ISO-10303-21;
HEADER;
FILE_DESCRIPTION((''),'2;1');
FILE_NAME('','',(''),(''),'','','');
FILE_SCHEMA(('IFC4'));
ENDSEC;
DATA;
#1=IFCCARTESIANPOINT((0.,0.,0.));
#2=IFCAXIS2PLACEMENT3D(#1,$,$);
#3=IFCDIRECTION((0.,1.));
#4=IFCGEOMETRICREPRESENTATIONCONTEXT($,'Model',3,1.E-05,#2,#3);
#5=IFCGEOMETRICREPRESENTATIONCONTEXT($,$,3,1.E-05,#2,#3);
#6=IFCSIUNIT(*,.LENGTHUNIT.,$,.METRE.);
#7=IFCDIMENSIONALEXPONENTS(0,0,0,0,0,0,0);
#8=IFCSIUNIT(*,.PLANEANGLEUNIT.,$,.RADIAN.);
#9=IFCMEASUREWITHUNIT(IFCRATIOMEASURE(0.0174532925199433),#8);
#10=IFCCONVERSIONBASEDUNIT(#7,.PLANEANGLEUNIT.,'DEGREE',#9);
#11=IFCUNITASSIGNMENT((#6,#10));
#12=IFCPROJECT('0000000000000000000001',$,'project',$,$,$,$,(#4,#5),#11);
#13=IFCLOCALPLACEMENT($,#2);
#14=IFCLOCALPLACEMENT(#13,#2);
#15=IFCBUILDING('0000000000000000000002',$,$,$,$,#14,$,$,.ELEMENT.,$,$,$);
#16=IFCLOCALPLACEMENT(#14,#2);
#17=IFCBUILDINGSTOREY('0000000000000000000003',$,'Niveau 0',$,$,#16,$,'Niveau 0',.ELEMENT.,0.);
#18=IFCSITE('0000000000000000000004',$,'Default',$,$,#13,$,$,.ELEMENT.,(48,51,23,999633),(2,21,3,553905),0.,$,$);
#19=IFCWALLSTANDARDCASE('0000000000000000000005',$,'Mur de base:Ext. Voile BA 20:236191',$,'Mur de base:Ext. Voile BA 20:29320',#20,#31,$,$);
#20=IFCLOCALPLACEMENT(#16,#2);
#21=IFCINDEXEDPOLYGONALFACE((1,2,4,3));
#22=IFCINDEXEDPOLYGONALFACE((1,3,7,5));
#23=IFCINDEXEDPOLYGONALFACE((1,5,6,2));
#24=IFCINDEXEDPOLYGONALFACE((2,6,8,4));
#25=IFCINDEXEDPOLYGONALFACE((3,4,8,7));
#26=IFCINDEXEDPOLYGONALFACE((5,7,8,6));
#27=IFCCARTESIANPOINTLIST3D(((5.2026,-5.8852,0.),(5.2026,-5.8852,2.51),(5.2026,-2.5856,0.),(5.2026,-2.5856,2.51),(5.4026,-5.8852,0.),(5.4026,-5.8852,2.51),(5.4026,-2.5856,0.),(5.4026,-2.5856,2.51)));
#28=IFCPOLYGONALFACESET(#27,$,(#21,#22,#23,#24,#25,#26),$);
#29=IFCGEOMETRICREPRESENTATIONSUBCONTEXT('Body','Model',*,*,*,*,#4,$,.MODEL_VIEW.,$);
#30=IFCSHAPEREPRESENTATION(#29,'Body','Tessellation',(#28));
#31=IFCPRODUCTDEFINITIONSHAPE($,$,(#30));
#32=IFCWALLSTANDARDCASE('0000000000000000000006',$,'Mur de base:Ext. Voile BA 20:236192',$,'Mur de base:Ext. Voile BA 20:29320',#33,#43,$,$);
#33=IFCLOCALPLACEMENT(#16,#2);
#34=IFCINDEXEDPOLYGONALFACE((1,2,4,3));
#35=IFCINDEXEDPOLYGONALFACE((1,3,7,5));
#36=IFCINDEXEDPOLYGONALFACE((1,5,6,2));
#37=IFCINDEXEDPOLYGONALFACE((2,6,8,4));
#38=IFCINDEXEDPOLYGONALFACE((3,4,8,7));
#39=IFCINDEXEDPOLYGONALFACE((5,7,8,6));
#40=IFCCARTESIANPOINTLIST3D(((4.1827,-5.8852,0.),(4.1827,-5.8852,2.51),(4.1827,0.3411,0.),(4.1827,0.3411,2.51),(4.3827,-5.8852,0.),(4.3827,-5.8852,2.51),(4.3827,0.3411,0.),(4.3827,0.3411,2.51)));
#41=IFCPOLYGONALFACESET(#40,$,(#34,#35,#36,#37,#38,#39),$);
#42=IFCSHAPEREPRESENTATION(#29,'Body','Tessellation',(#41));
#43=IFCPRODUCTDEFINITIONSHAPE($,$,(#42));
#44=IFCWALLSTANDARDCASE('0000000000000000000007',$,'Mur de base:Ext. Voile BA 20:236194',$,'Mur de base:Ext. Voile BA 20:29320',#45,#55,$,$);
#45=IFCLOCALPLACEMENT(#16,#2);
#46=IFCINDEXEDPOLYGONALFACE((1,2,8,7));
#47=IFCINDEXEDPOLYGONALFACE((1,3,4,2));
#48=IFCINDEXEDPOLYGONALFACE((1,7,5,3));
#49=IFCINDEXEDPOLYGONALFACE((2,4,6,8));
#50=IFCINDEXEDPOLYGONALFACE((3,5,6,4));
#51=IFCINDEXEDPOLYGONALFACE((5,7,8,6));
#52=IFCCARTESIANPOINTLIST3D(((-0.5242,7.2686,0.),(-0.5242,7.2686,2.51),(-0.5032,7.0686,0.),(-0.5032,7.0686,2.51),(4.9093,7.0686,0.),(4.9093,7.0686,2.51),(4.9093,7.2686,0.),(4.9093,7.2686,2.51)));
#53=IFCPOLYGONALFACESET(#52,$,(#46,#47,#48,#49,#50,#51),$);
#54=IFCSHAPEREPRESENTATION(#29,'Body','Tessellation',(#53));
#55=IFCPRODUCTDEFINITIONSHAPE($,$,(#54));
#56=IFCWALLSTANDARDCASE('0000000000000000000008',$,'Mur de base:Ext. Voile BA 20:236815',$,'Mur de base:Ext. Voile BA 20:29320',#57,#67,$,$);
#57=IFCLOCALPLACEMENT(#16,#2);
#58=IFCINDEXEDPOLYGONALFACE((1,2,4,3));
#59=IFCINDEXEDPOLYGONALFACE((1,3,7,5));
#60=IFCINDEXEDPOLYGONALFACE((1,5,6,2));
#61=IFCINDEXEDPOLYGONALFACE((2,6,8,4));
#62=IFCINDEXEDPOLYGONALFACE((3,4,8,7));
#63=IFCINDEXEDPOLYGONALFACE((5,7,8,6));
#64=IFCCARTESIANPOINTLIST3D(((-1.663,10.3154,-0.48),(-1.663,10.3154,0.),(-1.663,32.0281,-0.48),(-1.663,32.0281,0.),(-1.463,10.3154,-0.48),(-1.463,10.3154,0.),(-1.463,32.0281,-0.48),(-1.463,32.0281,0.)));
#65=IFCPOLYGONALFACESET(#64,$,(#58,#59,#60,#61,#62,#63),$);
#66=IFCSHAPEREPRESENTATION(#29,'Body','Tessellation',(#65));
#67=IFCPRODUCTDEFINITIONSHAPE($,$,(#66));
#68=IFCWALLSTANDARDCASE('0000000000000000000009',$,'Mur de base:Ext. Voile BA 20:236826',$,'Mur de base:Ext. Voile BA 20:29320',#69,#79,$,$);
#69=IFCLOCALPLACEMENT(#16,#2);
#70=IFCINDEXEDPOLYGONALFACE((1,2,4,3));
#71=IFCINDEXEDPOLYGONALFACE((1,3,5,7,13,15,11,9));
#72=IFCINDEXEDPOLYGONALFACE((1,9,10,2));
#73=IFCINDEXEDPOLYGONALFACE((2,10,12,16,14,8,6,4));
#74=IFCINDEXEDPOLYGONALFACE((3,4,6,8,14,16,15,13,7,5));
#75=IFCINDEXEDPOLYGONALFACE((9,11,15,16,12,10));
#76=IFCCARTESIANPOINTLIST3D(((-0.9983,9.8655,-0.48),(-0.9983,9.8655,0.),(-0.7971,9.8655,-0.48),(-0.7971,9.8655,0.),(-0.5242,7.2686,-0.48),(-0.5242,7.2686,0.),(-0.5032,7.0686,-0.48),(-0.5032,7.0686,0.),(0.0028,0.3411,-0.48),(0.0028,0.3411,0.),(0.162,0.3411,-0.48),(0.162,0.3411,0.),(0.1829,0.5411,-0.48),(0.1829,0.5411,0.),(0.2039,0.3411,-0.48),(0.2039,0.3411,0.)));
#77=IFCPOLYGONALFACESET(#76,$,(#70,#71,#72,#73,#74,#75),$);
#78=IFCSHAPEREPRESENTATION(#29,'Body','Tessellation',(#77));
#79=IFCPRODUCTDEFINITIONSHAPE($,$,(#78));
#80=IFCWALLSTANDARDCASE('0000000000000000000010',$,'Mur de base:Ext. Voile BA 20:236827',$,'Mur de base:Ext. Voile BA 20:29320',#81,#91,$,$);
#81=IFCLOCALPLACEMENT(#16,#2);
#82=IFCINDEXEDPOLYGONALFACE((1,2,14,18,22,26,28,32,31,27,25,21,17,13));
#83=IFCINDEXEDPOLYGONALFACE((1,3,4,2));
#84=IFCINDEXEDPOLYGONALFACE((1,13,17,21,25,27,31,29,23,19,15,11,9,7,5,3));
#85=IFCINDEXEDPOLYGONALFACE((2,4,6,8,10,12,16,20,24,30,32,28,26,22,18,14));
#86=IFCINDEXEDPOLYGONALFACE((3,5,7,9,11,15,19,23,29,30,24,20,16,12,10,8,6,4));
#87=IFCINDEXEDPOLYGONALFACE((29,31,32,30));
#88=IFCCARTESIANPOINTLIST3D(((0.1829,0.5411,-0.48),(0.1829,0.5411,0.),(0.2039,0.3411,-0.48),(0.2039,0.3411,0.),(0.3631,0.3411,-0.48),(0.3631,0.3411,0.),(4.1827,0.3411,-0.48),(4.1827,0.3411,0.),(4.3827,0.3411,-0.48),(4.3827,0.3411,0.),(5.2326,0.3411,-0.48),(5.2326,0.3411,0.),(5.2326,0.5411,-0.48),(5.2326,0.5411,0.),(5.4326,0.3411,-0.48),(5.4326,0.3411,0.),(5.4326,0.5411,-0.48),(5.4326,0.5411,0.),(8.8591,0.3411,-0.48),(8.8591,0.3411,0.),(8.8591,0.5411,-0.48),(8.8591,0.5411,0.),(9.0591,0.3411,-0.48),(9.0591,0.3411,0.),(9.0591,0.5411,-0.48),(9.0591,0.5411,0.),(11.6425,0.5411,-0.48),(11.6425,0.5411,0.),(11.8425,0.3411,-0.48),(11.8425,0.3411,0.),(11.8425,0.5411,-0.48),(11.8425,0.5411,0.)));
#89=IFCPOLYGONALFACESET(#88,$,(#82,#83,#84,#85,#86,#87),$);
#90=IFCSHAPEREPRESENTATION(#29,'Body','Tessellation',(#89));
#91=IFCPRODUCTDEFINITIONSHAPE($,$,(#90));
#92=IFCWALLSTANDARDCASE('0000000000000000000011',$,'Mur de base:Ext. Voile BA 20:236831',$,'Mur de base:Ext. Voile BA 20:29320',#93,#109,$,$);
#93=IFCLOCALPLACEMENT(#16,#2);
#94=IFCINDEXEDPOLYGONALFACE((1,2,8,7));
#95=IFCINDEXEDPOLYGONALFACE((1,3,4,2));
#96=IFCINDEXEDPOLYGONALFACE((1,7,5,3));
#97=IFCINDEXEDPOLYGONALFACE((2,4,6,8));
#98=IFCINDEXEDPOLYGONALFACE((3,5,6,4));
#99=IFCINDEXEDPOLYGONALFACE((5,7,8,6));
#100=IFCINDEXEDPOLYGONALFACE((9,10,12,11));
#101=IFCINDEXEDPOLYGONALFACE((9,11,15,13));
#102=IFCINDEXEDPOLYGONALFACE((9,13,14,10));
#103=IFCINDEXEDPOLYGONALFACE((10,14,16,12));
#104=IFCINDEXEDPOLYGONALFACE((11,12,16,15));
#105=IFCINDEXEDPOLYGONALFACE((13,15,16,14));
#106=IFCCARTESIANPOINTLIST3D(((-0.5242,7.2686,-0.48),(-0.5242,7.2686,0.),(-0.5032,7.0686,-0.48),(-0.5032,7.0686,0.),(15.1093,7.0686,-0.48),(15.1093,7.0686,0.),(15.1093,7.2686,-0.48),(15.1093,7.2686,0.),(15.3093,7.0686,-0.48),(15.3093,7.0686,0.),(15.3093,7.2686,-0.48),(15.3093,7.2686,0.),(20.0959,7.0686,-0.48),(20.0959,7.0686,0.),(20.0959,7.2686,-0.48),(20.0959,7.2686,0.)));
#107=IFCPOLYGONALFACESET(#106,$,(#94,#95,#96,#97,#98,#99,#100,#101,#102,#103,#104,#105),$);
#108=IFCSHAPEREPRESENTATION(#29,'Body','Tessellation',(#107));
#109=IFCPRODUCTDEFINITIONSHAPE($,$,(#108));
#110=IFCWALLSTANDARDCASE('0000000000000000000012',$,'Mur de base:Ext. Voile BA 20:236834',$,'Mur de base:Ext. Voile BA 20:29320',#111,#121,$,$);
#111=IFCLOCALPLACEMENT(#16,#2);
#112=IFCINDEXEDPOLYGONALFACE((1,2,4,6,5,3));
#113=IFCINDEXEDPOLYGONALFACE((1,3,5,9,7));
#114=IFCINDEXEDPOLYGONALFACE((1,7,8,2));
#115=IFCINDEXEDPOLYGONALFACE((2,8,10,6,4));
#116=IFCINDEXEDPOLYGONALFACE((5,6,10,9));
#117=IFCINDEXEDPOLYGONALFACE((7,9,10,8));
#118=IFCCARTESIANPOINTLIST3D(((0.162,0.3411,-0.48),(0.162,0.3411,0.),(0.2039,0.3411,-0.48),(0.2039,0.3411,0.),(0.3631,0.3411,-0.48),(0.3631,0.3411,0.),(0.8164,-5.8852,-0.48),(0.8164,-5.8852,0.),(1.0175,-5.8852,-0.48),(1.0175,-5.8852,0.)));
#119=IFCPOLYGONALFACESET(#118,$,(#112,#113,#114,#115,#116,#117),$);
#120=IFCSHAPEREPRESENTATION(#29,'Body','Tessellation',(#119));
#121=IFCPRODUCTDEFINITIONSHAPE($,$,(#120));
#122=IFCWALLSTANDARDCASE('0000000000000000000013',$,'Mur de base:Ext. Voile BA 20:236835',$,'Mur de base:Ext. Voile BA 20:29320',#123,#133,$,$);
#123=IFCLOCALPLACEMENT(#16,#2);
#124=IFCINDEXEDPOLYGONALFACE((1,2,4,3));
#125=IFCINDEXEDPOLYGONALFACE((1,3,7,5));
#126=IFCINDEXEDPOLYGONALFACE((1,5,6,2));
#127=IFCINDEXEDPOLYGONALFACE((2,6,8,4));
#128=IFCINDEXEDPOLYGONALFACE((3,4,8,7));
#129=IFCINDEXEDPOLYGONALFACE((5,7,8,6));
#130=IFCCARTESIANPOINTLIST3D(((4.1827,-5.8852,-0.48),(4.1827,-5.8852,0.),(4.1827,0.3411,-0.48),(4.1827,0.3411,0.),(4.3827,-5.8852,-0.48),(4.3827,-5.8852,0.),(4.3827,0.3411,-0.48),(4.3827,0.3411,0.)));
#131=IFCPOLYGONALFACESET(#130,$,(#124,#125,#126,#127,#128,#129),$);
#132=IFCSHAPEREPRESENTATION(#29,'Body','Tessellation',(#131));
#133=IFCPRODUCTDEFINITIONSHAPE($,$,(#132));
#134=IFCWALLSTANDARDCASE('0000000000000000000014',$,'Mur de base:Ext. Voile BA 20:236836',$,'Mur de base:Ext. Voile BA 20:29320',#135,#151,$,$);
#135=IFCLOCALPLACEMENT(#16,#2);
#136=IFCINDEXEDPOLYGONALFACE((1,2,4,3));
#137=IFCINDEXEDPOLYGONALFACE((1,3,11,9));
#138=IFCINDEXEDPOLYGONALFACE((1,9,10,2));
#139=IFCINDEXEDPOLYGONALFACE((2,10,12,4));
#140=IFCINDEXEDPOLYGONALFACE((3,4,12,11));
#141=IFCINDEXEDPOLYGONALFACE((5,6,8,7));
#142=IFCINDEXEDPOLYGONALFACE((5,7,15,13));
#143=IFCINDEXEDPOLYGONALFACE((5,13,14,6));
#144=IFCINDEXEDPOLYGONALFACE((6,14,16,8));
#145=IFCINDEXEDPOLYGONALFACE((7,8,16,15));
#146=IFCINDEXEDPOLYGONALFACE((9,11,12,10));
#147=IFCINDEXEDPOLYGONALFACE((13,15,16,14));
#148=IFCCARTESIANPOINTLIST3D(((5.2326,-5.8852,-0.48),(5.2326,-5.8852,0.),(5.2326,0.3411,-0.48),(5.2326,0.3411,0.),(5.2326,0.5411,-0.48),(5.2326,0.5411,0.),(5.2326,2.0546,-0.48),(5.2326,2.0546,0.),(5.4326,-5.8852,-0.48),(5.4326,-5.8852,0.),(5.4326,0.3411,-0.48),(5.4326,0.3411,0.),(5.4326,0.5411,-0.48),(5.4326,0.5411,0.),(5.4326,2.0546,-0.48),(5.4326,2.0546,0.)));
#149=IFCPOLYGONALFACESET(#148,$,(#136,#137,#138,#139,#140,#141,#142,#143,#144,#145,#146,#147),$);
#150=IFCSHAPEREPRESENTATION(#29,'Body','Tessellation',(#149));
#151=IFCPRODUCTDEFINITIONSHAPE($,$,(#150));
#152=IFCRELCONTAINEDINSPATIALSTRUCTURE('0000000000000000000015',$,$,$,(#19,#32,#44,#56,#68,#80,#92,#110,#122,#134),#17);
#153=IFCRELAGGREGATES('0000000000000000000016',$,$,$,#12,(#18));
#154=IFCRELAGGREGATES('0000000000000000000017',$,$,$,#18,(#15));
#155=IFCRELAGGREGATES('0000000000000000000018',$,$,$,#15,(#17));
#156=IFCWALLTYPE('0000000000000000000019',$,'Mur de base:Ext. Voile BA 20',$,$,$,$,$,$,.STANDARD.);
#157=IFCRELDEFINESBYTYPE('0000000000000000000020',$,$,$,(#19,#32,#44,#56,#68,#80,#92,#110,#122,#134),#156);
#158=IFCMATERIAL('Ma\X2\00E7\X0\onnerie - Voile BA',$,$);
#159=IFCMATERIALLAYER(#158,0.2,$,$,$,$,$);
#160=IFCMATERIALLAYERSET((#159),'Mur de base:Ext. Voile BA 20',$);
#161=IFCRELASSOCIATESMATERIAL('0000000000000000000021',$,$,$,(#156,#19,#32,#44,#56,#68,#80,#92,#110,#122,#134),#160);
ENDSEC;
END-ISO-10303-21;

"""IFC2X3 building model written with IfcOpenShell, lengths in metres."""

from ifc_helpers import new_model, entity, si_unit, converted_unit, direction, frame, frame_2d, origin, origin_2d_with_axis, place, context, subcontext, project, spatial, polyline, rectangle, outline, extrude, material, layer, layer_set, layer_usage, type_object, element, save


model = new_model("IFC2X3")

# Units and contexts
model_context = context("Model", 3, precision=1e-05, world=origin(), true_north=direction((0.0, 1.0)))
context_of_model = context(None, 3, precision=1e-05, world=origin(), true_north=direction((0.0, 1.0)))
body_context = subcontext(model_context, "Body", "Model", "MODEL_VIEW")
ifc_project = project(units=[si_unit("LENGTHUNIT", "METRE"), converted_unit("PLANEANGLEUNIT", "DEGREE", entity("IfcRatioMeasure", 0.0174532925199433), si_unit("PLANEANGLEUNIT", "RADIAN"), dimensions=[0, 0, 0, 0, 0, 0, 0])], contexts=[model_context, context_of_model])

# Site, building, storey
site_placement = place(None, origin())
site = spatial("IfcSite", under=ifc_project, at=site_placement, Name="Default", CompositionType="ELEMENT", RefLatitude=(48, 51, 23, 999633), RefLongitude=(2, 21, 3, 553905), RefElevation=0.0)
building_placement = place(site_placement, origin())
building = spatial("IfcBuilding", under=site, at=building_placement, CompositionType="ELEMENT")
storey_placement = place(building_placement, origin())
storey = spatial("IfcBuildingStorey", under=building, at=storey_placement, Name="Niveau 0", LongName="Niveau 0", CompositionType="ELEMENT", Elevation=0.0)

# Walls
ifc_material_1 = material(Name="Maçonnerie - Voile BA")
ifc_layer_1 = layer(ifc_material_1, 0.2)
ifc_layer_set_1 = layer_set([ifc_layer_1], Name="Mur de base:Ext. Voile BA 20")
wall_type = type_object("IfcWallType", Name="Mur de base:Ext. Voile BA 20", PredefinedType="STANDARD", material=ifc_layer_set_1)
ifc_layer_usage_1 = layer_usage(ifc_layer_set_1, "AXIS2", "NEGATIVE", 0.1)
wall_1_placement = place(storey_placement, frame((5.3026, -5.8852, 0.0), z_axis=(0.0, 0.0, 1.0), x_axis=(0.0, 1.0, 0.0)))
element("IfcWallStandardCase", 1, at=wall_1_placement, inside=storey, type_object=wall_type, material=ifc_layer_usage_1, Name="Mur de base:Ext. Voile BA 20:236191", ObjectType="Mur de base:Ext. Voile BA 20:29320", context=body_context, shape_type="SweptSolid", body=[
    extrude(rectangle(XDim=3.2995, YDim=0.2, at=frame_2d((1.6498, 0.0), x_axis=(-1.0, 0.0))), origin(), (0.0, 0.0, 1.0), 2.51),
])
ifc_layer_usage_2 = layer_usage(ifc_layer_set_1, "AXIS2", "NEGATIVE", 0.1)
wall_2_placement = place(storey_placement, frame((4.2827, -5.8852, 0.0), z_axis=(0.0, 0.0, 1.0), x_axis=(0.0, 1.0, 0.0)))
element("IfcWallStandardCase", 2, at=wall_2_placement, inside=storey, type_object=wall_type, material=ifc_layer_usage_2, Name="Mur de base:Ext. Voile BA 20:236192", ObjectType="Mur de base:Ext. Voile BA 20:29320", context=body_context, shape_type="SweptSolid", body=[
    extrude(rectangle(XDim=6.2263, YDim=0.2, at=frame_2d((3.1131, 0.0), x_axis=(-1.0, 0.0))), origin(), (0.0, 0.0, 1.0), 2.51),
])
ifc_layer_usage_3 = layer_usage(ifc_layer_set_1, "AXIS2", "NEGATIVE", 0.1)
wall_3_placement = place(storey_placement, frame((4.9093, 7.1686, 0.0), z_axis=(0.0, 0.0, 1.0), x_axis=(-1.0, 0.0, 0.0)))
element("IfcWallStandardCase", 3, at=wall_3_placement, inside=storey, type_object=wall_type, material=ifc_layer_usage_3, Name="Mur de base:Ext. Voile BA 20:236194", ObjectType="Mur de base:Ext. Voile BA 20:29320", context=body_context, shape_type="SweptSolid", body=[
    extrude(outline(polyline([(5.4335, -0.1), (5.4124, 0.1), (0.0, 0.1), (0.0, -0.1), (5.4335, -0.1)])), origin(), (0.0, 0.0, 1.0), 2.51),
])
ifc_layer_usage_4 = layer_usage(ifc_layer_set_1, "AXIS2", "NEGATIVE", 0.1)
wall_4_placement = place(storey_placement, frame((-1.563, 10.3154, -0.48), z_axis=(0.0, 0.0, 1.0), x_axis=(0.0, 1.0, 0.0)))
element("IfcWallStandardCase", 4, at=wall_4_placement, inside=storey, type_object=wall_type, material=ifc_layer_usage_4, Name="Mur de base:Ext. Voile BA 20:236815", ObjectType="Mur de base:Ext. Voile BA 20:29320", context=body_context, shape_type="SweptSolid", body=[
    extrude(rectangle(XDim=21.7127, YDim=0.2, at=frame_2d((10.8563, 0.0), x_axis=(-1.0, 0.0))), origin(), (0.0, 0.0, 1.0), 0.48),
])
ifc_layer_usage_5 = layer_usage(ifc_layer_set_1, "AXIS2", "NEGATIVE", 0.1)
wall_5_placement = place(storey_placement, frame((-0.8988, 9.8759, -0.48), z_axis=(0.0, 0.0, 1.0), x_axis=(0.104528, -0.994522, 0.0)))
element("IfcWallStandardCase", 5, at=wall_5_placement, inside=storey, type_object=wall_type, material=ifc_layer_usage_5, Name="Mur de base:Ext. Voile BA 20:236826", ObjectType="Mur de base:Ext. Voile BA 20:29320", context=body_context, shape_type="SweptSolid", body=[
    extrude(outline(polyline([(9.5768, -0.1), (9.5934, 0.0584), (9.5978, 0.1), (9.3967, 0.1), (2.8333, 0.1), (2.6322, 0.1), (0.021, 0.1), (0.0, -0.1), (9.5768, -0.1)])), origin(), (0.0, 0.0, 1.0), 0.48),
])
ifc_layer_usage_6 = layer_usage(ifc_layer_set_1, "AXIS2", "NEGATIVE", 0.1)
wall_6_placement = place(storey_placement, frame((0.1829, 0.4411, -0.48)))
element("IfcWallStandardCase", 6, at=wall_6_placement, inside=storey, type_object=wall_type, material=ifc_layer_usage_6, Name="Mur de base:Ext. Voile BA 20:236827", ObjectType="Mur de base:Ext. Voile BA 20:29320", context=body_context, shape_type="SweptSolid", body=[
    extrude(outline(polyline([(11.6596, -0.1), (11.6596, 0.1), (11.4596, 0.1), (8.8762, 0.1), (8.6762, 0.1), (5.2497, 0.1), (5.0497, 0.1), (0.0, 0.1), (0.021, -0.1), (0.1802, -0.1), (3.9998, -0.1), (4.1998, -0.1), (5.0497, -0.1), (5.2497, -0.1), (8.6762, -0.1), (8.8762, -0.1), (11.6596, -0.1)])), origin(), (0.0, 0.0, 1.0), 0.48),
])

# Wall, opening
ifc_layer_usage_7 = layer_usage(ifc_layer_set_1, "AXIS2", "NEGATIVE", 0.1)
wall_7_placement = place(storey_placement, frame((-0.5242, 7.1686, -0.48)))
wall_7 = element("IfcWallStandardCase", 7, at=wall_7_placement, inside=storey, type_object=wall_type, material=ifc_layer_usage_7, Name="Mur de base:Ext. Voile BA 20:236831", ObjectType="Mur de base:Ext. Voile BA 20:29320", context=body_context, shape_type="SweptSolid", body=[
    extrude(outline(polyline([(0.0, 0.1), (0.021, -0.1), (20.6201, -0.1), (20.6201, 0.1), (0.0, 0.1)])), origin(), (0.0, 0.0, 1.0), 0.48),
])
opening_1_placement = place(storey_placement, frame((-0.5242, 7.1686, -0.48)))
element("IfcOpeningElement", 8, at=opening_1_placement, cuts=wall_7, ObjectType="Opening", context=body_context, shape_type="SweptSolid", body=[
    extrude(rectangle(XDim=0.48, YDim=0.2, at=frame_2d((0.0, 0.0), x_axis=(1.0, 0.0))), frame((15.6335, 0.0, 0.24), z_axis=(1.0, 0.0, 0.0), x_axis=(0.0, 0.0, -1.0)), (0.0, 0.0, 1.0), 0.2),
])

# Walls
ifc_layer_usage_8 = layer_usage(ifc_layer_set_1, "AXIS2", "NEGATIVE", 0.1)
wall_8_placement = place(storey_placement, frame((0.2615, 0.3516, -0.48), z_axis=(0.0, 0.0, 1.0), x_axis=(0.104528, -0.994522, 0.0)))
element("IfcWallStandardCase", 9, at=wall_8_placement, inside=storey, type_object=wall_type, material=ifc_layer_usage_8, Name="Mur de base:Ext. Voile BA 20:236834", ObjectType="Mur de base:Ext. Voile BA 20:29320", context=body_context, shape_type="SweptSolid", body=[
    extrude(outline(polyline([(6.2606, -0.1), (6.2816, 0.1), (0.021, 0.1), (0.0044, -0.0584), (0.0, -0.1), (6.2606, -0.1)])), origin(), (0.0, 0.0, 1.0), 0.48),
])
ifc_layer_usage_9 = layer_usage(ifc_layer_set_1, "AXIS2", "NEGATIVE", 0.1)
wall_9_placement = place(storey_placement, frame((4.2827, 0.3411, -0.48), z_axis=(0.0, 0.0, 1.0), x_axis=(0.0, -1.0, 0.0)))
element("IfcWallStandardCase", 10, at=wall_9_placement, inside=storey, type_object=wall_type, material=ifc_layer_usage_9, Name="Mur de base:Ext. Voile BA 20:236835", ObjectType="Mur de base:Ext. Voile BA 20:29320", context=body_context, shape_type="SweptSolid", body=[
    extrude(rectangle(XDim=6.2263, YDim=0.2, at=frame_2d((3.1131, 0.0), x_axis=(-1.0, 0.0))), origin(), (0.0, 0.0, 1.0), 0.48),
])

# Wall, opening
ifc_layer_usage_10 = layer_usage(ifc_layer_set_1, "AXIS2", "NEGATIVE", 0.1)
wall_10_placement = place(storey_placement, frame((5.3326, 2.0546, -0.48), z_axis=(0.0, 0.0, 1.0), x_axis=(0.0, -1.0, 0.0)))
wall_10 = element("IfcWallStandardCase", 11, at=wall_10_placement, inside=storey, type_object=wall_type, material=ifc_layer_usage_10, Name="Mur de base:Ext. Voile BA 20:236836", ObjectType="Mur de base:Ext. Voile BA 20:29320", context=body_context, shape_type="SweptSolid", body=[
    extrude(rectangle(XDim=7.9398, YDim=0.2, at=frame_2d((3.9699, 0.0), x_axis=(-1.0, 0.0))), origin(), (0.0, 0.0, 1.0), 0.48),
])
opening_2_placement = place(storey_placement, frame((5.3326, 2.0546, -0.48), z_axis=(0.0, 0.0, 1.0), x_axis=(0.0, -1.0, 0.0)))
element("IfcOpeningElement", 12, at=opening_2_placement, cuts=wall_10, ObjectType="Opening", context=body_context, shape_type="SweptSolid", body=[
    extrude(rectangle(XDim=0.48, YDim=0.2, at=origin_2d_with_axis()), frame((1.7135, 0.0, 0.24), z_axis=(-1.0, 0.0, 0.0), x_axis=(0.0, 0.0, 1.0)), (0.0, 0.0, 1.0), 0.2),
])

save(model, "model.ifc")
